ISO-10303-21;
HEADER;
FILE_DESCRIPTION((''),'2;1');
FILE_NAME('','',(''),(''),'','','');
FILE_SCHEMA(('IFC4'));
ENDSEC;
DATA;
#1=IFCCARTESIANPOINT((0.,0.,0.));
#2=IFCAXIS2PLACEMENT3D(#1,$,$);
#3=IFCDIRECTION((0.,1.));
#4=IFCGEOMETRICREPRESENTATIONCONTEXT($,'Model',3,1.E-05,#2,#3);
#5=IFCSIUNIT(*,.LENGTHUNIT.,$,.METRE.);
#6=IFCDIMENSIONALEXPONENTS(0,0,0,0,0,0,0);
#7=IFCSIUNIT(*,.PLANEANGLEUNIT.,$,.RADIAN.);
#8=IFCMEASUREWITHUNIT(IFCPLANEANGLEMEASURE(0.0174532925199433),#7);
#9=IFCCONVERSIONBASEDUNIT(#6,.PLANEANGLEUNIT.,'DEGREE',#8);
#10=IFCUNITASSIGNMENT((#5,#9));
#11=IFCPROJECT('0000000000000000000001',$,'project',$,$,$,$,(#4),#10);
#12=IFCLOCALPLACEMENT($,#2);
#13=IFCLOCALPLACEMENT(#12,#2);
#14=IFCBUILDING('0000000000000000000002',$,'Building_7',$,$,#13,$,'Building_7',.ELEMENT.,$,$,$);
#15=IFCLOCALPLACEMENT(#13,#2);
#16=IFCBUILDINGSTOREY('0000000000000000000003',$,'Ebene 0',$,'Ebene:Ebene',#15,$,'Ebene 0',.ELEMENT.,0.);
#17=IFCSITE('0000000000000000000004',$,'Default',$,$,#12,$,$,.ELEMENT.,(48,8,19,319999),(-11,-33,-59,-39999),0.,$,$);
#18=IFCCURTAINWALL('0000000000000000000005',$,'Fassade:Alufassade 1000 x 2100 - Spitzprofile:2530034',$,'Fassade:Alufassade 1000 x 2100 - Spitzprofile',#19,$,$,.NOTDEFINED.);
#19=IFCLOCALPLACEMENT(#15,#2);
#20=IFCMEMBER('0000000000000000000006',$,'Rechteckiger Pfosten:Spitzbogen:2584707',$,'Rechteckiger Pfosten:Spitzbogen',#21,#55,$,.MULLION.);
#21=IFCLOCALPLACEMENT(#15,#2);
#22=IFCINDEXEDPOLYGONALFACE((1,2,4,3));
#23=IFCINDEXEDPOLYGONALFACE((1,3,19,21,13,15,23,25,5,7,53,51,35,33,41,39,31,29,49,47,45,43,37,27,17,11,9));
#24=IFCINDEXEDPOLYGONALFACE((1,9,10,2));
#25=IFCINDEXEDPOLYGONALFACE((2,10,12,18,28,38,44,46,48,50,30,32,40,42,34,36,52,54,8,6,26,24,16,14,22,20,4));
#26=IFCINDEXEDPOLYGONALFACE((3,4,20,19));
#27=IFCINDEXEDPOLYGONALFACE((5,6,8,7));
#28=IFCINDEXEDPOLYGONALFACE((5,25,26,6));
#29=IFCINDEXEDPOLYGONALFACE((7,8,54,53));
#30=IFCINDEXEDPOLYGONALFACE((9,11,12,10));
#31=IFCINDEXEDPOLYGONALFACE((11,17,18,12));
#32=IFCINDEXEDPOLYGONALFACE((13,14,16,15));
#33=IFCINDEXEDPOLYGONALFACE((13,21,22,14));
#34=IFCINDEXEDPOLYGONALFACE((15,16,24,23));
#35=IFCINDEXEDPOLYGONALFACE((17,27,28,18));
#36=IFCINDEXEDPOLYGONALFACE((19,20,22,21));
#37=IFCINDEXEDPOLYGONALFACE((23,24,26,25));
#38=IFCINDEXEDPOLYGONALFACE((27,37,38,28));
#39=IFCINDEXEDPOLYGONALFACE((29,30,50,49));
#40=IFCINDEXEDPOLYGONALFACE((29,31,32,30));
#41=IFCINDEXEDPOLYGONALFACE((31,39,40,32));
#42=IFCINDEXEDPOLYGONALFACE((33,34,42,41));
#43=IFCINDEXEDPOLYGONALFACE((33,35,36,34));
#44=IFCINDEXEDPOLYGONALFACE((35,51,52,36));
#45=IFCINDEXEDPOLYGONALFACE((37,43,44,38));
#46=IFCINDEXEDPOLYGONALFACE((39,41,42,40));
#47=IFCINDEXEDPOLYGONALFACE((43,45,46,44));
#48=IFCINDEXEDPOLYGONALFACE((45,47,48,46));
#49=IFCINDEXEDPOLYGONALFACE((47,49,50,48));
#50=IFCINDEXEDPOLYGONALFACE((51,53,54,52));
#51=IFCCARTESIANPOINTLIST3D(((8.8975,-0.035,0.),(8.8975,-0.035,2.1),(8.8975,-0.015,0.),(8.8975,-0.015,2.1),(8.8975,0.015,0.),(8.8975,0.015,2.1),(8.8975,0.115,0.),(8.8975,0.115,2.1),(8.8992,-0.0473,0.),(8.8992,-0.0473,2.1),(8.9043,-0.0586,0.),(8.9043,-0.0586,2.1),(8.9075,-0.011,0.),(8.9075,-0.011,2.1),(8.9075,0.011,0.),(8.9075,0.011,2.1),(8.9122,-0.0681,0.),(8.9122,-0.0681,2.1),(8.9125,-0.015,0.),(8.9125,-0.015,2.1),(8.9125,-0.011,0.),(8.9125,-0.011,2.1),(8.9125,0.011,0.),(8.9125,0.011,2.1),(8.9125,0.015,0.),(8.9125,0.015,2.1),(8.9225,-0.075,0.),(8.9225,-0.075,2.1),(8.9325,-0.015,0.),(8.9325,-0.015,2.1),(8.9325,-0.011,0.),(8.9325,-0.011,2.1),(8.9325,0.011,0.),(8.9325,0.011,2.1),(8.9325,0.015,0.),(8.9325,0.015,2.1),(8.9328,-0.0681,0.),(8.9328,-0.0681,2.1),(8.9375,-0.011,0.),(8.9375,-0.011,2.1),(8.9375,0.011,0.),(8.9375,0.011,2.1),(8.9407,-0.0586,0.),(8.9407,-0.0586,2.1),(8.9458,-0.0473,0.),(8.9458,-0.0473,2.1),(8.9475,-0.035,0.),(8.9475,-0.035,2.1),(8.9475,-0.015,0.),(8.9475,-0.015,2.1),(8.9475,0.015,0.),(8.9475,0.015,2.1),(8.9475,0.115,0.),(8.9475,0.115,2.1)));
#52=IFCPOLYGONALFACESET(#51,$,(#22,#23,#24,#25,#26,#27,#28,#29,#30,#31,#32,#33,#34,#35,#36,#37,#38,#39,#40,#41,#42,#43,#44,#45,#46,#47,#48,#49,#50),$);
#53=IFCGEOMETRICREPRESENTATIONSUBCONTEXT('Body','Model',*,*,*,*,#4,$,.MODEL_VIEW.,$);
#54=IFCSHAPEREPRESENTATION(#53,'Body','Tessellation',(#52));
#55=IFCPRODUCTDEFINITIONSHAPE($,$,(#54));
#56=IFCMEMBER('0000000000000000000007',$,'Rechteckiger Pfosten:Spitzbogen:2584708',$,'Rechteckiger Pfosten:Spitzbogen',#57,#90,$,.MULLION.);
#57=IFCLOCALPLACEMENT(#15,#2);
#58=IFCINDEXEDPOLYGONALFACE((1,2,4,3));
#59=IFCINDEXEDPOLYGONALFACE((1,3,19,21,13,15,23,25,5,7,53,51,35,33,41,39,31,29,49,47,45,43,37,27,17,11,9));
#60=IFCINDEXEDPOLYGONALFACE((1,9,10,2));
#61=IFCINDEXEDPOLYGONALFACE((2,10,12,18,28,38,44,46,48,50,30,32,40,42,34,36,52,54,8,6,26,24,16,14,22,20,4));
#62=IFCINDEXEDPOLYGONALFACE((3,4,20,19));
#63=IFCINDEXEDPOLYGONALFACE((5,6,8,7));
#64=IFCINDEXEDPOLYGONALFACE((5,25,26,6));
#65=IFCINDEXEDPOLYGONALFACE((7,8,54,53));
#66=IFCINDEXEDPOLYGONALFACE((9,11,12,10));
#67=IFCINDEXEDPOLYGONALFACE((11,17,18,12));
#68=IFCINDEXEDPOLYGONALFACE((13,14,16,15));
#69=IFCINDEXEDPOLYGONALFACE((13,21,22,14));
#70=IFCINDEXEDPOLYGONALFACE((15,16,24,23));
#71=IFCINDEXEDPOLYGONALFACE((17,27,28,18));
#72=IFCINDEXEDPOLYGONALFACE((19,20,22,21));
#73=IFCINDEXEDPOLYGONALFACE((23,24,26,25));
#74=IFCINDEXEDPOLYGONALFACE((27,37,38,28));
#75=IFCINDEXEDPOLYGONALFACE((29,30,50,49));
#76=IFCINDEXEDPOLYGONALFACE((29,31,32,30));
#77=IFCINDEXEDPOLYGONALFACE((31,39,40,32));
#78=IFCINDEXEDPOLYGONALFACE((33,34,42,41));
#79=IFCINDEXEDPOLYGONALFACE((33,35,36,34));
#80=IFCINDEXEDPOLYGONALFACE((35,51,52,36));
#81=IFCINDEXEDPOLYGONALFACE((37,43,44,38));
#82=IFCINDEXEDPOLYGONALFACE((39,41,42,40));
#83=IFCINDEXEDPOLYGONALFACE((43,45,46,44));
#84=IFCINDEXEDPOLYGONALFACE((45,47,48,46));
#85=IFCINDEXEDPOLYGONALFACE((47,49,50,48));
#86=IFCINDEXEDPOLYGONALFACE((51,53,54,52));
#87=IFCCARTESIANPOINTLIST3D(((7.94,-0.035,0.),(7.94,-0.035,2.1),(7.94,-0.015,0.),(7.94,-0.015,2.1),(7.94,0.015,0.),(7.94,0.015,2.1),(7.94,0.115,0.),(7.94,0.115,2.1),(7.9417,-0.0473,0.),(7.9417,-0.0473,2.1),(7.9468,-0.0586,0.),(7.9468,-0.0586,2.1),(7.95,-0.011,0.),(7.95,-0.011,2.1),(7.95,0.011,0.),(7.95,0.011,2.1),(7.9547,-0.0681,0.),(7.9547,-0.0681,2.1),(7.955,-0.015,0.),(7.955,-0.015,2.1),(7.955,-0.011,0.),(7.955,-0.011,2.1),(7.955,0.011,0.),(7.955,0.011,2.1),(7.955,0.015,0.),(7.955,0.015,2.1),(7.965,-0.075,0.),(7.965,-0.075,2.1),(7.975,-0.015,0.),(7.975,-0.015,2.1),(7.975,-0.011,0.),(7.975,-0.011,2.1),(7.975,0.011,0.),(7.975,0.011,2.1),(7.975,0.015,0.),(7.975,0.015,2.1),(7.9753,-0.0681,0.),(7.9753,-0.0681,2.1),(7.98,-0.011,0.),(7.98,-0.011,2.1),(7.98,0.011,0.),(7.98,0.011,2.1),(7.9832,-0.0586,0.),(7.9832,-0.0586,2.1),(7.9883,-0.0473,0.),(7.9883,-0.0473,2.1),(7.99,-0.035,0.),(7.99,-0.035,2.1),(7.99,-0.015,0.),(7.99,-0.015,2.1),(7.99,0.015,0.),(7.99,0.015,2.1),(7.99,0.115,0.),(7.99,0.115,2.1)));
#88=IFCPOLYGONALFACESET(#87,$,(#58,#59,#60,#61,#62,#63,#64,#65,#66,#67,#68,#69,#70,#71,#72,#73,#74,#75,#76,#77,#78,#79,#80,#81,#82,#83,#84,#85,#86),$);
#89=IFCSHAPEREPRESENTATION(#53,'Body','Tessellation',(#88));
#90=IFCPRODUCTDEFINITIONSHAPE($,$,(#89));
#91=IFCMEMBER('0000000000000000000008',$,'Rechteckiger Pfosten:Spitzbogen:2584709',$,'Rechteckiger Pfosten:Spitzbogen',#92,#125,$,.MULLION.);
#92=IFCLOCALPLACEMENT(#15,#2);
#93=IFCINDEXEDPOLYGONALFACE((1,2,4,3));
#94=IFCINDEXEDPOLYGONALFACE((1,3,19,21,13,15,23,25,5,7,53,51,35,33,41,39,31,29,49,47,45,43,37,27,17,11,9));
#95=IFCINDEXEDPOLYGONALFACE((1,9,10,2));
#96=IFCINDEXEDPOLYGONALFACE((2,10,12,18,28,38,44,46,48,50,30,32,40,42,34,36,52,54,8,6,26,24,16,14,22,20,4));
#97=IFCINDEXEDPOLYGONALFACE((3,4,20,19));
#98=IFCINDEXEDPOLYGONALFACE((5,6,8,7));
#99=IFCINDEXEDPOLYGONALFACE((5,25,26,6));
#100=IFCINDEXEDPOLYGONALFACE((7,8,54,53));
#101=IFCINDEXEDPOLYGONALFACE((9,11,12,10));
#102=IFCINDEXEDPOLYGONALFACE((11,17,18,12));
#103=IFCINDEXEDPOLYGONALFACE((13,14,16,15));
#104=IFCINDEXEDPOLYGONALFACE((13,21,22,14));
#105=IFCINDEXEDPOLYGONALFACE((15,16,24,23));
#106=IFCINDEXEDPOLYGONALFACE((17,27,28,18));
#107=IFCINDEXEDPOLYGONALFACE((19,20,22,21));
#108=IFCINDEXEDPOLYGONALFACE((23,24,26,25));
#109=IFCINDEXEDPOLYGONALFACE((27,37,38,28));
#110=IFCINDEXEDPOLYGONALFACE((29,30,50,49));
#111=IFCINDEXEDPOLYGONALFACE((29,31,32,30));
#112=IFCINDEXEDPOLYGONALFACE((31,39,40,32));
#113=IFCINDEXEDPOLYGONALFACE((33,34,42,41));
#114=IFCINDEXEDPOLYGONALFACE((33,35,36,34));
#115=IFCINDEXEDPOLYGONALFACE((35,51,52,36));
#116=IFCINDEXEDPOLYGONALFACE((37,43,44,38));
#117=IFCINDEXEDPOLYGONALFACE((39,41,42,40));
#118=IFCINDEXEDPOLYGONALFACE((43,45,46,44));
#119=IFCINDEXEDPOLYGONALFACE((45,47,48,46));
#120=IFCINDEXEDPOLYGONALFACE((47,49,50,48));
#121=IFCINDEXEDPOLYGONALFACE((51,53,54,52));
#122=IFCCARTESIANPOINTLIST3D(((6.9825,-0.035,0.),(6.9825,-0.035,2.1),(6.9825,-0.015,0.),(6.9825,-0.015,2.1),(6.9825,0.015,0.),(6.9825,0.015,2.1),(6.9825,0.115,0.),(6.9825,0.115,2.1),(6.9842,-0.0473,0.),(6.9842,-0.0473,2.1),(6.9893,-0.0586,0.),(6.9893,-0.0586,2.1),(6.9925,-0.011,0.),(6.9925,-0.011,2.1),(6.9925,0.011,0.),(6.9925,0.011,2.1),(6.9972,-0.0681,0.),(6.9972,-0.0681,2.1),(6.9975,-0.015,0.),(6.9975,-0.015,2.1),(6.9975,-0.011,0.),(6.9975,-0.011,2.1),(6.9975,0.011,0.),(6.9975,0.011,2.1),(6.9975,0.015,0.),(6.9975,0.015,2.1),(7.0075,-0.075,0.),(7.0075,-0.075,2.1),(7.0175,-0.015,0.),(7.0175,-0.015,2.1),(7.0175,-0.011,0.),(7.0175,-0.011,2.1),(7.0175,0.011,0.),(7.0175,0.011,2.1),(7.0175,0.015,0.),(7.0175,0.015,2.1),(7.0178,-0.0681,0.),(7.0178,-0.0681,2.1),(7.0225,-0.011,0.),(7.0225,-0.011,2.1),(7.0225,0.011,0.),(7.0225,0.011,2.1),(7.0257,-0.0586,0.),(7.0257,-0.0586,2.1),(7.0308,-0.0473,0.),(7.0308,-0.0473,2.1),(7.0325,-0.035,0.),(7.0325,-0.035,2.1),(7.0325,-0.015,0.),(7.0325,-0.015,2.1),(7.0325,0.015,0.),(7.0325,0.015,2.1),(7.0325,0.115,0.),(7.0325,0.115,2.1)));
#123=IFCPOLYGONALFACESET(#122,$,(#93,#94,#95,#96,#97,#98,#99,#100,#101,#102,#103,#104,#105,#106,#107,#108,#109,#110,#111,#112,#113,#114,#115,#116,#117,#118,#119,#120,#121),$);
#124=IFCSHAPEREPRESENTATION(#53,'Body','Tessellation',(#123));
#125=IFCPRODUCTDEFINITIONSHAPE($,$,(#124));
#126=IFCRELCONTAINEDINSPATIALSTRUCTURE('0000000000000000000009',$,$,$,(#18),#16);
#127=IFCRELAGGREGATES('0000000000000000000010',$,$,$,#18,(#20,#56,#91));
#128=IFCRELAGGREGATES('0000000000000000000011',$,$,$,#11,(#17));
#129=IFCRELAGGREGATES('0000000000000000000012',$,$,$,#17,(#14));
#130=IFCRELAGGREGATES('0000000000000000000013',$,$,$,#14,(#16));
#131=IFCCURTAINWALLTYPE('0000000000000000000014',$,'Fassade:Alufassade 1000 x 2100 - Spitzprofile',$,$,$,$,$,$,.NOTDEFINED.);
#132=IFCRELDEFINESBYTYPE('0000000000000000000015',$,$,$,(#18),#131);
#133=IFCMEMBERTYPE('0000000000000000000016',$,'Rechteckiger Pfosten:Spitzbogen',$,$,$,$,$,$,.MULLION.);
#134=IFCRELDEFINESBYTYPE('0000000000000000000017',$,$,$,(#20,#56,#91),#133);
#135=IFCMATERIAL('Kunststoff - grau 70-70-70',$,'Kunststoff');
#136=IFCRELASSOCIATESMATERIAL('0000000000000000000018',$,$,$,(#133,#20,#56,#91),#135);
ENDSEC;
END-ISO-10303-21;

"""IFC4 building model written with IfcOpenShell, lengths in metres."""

from ifc_helpers import new_model, entity, si_unit, converted_unit, direction, frame, origin, place, context, subcontext, project, spatial, line, arc, indexed_curve, outline, extrude, source, transform, mapped, material, type_object, type_shapes, element, aggregate, save


model = new_model("IFC4")

# Units and contexts
model_context = context("Model", 3, precision=1e-05, world=origin(), true_north=direction((0.0, 1.0)))
body_context = subcontext(model_context, "Body", "Model", "MODEL_VIEW")
ifc_project = project(units=[si_unit("LENGTHUNIT", "METRE"), converted_unit("PLANEANGLEUNIT", "DEGREE", entity("IfcPlaneAngleMeasure", 0.0174532925199433), si_unit("PLANEANGLEUNIT", "RADIAN"), dimensions=[0, 0, 0, 0, 0, 0, 0])], contexts=[model_context])

# Site, building, storey
site_placement = place(None, origin())
site = spatial("IfcSite", under=ifc_project, at=site_placement, Name="Default", CompositionType="ELEMENT", RefLatitude=(48, 8, 19, 319999), RefLongitude=(-11, -33, -59, -39999), RefElevation=0.0)
building_placement = place(site_placement, origin())
building = spatial("IfcBuilding", under=site, at=building_placement, Name="Building_7", LongName="Building_7", CompositionType="ELEMENT")
storey_placement = place(building_placement, origin())
storey = spatial("IfcBuildingStorey", under=building, at=storey_placement, Name="Ebene 0", ObjectType="Ebene:Ebene", LongName="Ebene 0", CompositionType="ELEMENT", Elevation=0.0)

# Curtain wall, members
curtain_wall_type = type_object("IfcCurtainWallType", Name="Fassade:Alufassade 1000 x 2100 - Spitzprofile", PredefinedType="NOTDEFINED")
curtain_wall_placement = place(storey_placement, origin())
curtain_wall = element("IfcCurtainWall", 1, at=curtain_wall_placement, inside=storey, type_object=curtain_wall_type, Name="Fassade:Alufassade 1000 x 2100 - Spitzprofile:2530034", ObjectType="Fassade:Alufassade 1000 x 2100 - Spitzprofile", PredefinedType="NOTDEFINED")
ifc_material = material(Name="Kunststoff - grau 70-70-70", Category="Kunststoff")
member_type_1 = type_object("IfcMemberType", Name="Rechteckiger Pfosten:Spitzbogen", PredefinedType="MULLION", material=ifc_material)
shared_shape_1 = source(origin(), body_context, "Body", "SweptSolid", [
    extrude(outline(indexed_curve([(-0.111, -0.025), (-0.011, -0.025), (-0.011, -0.01), (-0.007, -0.01), (-0.007, -0.015), (0.015, -0.015), (0.015, -0.01), (0.019, -0.01), (0.019, -0.025), (0.039, -0.025), (0.0626, -0.0182), (0.079, 0.0), (0.0626, 0.0182), (0.039, 0.025), (0.019, 0.025), (0.019, 0.01), (0.015, 0.01), (0.015, 0.015), (-0.007, 0.015), (-0.007, 0.01), (-0.011, 0.01), (-0.011, 0.025), (-0.111, 0.025)], segments=[line(1, 2, 3, 4, 5, 6, 7, 8, 9, 10), arc(10, 11, 12), arc(12, 13, 14), line(14, 15, 16, 17, 18, 19, 20, 21, 22, 23, 1)], self_intersect=False)), frame((0.0, 0.004, -2.1), z_axis=(0.0, 0.0, 1.0), x_axis=(0.0, -1.0, 0.0)), (0.0, 0.0, 1.0), 2.1),
])
type_shapes(member_type_1, [shared_shape_1])
member_1_placement = place(curtain_wall_placement, frame((8.9225, 0.0, 0.0), z_axis=(0.0, 0.0, -1.0), x_axis=(-1.0, 0.0, 0.0)))
member_1 = element("IfcMember", 2, at=member_1_placement, type_object=member_type_1, material=ifc_material, Name="Rechteckiger Pfosten:Spitzbogen:2584707", ObjectType="Rechteckiger Pfosten:Spitzbogen", PredefinedType="MULLION", context=body_context, shape_type="MappedRepresentation", body=[
    mapped(shared_shape_1, transform((0.0, 0.0, 0.0), scale=1.0)),
])
member_2_placement = place(curtain_wall_placement, frame((7.965, 0.0, 0.0), z_axis=(0.0, 0.0, -1.0), x_axis=(-1.0, 0.0, 0.0)))
member_2 = element("IfcMember", 3, at=member_2_placement, type_object=member_type_1, material=ifc_material, Name="Rechteckiger Pfosten:Spitzbogen:2584708", ObjectType="Rechteckiger Pfosten:Spitzbogen", PredefinedType="MULLION", context=body_context, shape_type="MappedRepresentation", body=[
    mapped(shared_shape_1, transform((0.0, 0.0, 0.0), scale=1.0)),
])
member_3_placement = place(curtain_wall_placement, frame((7.0075, 0.0, 0.0), z_axis=(0.0, 0.0, -1.0), x_axis=(-1.0, 0.0, 0.0)))
member_3 = element("IfcMember", 4, at=member_3_placement, type_object=member_type_1, material=ifc_material, Name="Rechteckiger Pfosten:Spitzbogen:2584709", ObjectType="Rechteckiger Pfosten:Spitzbogen", PredefinedType="MULLION", context=body_context, shape_type="MappedRepresentation", body=[
    mapped(shared_shape_1, transform((0.0, 0.0, 0.0), scale=1.0)),
])
aggregate(curtain_wall, [member_1, member_2, member_3])

save(model, "model.ifc")
